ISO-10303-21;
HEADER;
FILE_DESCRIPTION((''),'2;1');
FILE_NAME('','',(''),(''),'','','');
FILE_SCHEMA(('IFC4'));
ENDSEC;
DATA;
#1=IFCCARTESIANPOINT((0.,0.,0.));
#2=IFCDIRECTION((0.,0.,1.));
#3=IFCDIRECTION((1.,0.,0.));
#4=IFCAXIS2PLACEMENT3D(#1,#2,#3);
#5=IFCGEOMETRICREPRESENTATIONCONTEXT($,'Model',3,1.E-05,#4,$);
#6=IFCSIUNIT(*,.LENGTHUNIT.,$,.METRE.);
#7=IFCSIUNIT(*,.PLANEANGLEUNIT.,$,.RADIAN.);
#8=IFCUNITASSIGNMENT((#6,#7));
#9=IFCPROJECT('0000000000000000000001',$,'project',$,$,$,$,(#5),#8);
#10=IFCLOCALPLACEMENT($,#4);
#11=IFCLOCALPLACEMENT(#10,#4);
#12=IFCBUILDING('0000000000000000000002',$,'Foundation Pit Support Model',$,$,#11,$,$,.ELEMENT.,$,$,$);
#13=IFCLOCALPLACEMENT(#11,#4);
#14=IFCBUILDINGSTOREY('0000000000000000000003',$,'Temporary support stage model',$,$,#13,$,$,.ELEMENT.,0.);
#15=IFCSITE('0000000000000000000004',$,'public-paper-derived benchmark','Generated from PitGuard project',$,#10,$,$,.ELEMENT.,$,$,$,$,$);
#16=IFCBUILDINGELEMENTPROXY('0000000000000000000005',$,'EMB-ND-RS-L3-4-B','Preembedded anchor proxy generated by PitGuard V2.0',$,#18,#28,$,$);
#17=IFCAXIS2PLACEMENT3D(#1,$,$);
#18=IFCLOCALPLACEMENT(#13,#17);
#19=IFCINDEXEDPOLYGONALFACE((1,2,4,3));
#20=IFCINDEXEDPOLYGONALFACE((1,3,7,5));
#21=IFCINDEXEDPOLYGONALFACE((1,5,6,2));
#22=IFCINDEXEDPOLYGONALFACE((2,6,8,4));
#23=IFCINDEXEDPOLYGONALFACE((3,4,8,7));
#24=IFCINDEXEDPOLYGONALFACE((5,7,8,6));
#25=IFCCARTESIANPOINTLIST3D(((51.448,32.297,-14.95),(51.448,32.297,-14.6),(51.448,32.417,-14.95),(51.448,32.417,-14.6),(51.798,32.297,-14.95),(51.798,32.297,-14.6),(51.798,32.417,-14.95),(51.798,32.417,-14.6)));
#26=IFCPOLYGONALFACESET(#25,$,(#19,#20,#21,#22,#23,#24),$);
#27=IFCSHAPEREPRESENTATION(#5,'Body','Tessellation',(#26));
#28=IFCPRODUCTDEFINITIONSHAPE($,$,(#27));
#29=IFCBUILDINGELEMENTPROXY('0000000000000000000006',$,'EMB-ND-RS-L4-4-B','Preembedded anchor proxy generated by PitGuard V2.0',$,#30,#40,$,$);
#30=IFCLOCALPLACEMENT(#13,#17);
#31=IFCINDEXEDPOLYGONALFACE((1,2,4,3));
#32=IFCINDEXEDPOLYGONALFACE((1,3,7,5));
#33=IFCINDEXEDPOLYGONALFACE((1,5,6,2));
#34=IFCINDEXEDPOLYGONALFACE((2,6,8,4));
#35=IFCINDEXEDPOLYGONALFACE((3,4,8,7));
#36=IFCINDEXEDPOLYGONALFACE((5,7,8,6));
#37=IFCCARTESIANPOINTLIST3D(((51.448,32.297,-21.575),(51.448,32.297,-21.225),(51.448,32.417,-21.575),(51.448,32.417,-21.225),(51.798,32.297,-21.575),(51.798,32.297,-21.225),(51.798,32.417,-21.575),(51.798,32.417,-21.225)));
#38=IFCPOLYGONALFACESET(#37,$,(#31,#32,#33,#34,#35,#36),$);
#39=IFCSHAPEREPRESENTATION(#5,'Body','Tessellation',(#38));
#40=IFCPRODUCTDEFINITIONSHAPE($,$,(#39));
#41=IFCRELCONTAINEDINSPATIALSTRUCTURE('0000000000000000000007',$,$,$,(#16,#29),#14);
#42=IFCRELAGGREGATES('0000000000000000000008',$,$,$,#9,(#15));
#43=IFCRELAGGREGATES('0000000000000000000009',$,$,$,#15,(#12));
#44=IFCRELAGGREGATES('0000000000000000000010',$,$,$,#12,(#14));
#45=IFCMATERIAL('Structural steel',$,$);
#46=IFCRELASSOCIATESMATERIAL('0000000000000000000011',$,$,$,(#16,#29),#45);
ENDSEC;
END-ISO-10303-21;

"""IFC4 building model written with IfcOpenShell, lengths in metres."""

from ifc_helpers import new_model, si_unit, frame, origin_with_axes, origin_2d, place, context, project, spatial, rectangle, extrude, material, element, save


model = new_model("IFC4")

# Units and contexts
model_context = context("Model", 3, precision=1e-05, world=origin_with_axes())
ifc_project = project(units=[si_unit("LENGTHUNIT", "METRE"), si_unit("PLANEANGLEUNIT", "RADIAN")], contexts=[model_context])

# Site, building, storey
site_placement = place(None, origin_with_axes())
site = spatial("IfcSite", under=ifc_project, at=site_placement, Name="public-paper-derived benchmark", Description="Generated from PitGuard project", CompositionType="ELEMENT")
building_placement = place(site_placement, origin_with_axes())
building = spatial("IfcBuilding", under=site, at=building_placement, Name="Foundation Pit Support Model", CompositionType="ELEMENT")
storey_placement = place(building_placement, origin_with_axes())
storey = spatial("IfcBuildingStorey", under=building, at=storey_placement, Name="Temporary support stage model", CompositionType="ELEMENT", Elevation=0.0)

# Shared definitions
ifc_material_1 = material(Name="Structural steel")

# Building element proxies
for number, where, z_axis, x_axis, name in (
    (1, (51.623, 32.357, -14.95), (0.0, 0.0, 1.0), (1.0, 0.0, 0.0), "EMB-ND-RS-L3-4-B"),
    (2, (51.623, 32.357, -21.575), (0.0, 0.0, 1.0), (1.0, 0.0, 0.0), "EMB-ND-RS-L4-4-B"),
):
    element("IfcBuildingElementProxy", number, at=place(storey_placement, frame(where, z_axis=z_axis, x_axis=x_axis)), inside=storey, material=ifc_material_1, Name=name, Description="Preembedded anchor proxy generated by PitGuard V2.0", context=model_context, shape_type="SweptSolid", body=[
        extrude(rectangle(XDim=0.35, YDim=0.12, at=origin_2d()), origin_with_axes(), (0.0, 0.0, 1.0), 0.35),
    ])

save(model, "model.ifc")
